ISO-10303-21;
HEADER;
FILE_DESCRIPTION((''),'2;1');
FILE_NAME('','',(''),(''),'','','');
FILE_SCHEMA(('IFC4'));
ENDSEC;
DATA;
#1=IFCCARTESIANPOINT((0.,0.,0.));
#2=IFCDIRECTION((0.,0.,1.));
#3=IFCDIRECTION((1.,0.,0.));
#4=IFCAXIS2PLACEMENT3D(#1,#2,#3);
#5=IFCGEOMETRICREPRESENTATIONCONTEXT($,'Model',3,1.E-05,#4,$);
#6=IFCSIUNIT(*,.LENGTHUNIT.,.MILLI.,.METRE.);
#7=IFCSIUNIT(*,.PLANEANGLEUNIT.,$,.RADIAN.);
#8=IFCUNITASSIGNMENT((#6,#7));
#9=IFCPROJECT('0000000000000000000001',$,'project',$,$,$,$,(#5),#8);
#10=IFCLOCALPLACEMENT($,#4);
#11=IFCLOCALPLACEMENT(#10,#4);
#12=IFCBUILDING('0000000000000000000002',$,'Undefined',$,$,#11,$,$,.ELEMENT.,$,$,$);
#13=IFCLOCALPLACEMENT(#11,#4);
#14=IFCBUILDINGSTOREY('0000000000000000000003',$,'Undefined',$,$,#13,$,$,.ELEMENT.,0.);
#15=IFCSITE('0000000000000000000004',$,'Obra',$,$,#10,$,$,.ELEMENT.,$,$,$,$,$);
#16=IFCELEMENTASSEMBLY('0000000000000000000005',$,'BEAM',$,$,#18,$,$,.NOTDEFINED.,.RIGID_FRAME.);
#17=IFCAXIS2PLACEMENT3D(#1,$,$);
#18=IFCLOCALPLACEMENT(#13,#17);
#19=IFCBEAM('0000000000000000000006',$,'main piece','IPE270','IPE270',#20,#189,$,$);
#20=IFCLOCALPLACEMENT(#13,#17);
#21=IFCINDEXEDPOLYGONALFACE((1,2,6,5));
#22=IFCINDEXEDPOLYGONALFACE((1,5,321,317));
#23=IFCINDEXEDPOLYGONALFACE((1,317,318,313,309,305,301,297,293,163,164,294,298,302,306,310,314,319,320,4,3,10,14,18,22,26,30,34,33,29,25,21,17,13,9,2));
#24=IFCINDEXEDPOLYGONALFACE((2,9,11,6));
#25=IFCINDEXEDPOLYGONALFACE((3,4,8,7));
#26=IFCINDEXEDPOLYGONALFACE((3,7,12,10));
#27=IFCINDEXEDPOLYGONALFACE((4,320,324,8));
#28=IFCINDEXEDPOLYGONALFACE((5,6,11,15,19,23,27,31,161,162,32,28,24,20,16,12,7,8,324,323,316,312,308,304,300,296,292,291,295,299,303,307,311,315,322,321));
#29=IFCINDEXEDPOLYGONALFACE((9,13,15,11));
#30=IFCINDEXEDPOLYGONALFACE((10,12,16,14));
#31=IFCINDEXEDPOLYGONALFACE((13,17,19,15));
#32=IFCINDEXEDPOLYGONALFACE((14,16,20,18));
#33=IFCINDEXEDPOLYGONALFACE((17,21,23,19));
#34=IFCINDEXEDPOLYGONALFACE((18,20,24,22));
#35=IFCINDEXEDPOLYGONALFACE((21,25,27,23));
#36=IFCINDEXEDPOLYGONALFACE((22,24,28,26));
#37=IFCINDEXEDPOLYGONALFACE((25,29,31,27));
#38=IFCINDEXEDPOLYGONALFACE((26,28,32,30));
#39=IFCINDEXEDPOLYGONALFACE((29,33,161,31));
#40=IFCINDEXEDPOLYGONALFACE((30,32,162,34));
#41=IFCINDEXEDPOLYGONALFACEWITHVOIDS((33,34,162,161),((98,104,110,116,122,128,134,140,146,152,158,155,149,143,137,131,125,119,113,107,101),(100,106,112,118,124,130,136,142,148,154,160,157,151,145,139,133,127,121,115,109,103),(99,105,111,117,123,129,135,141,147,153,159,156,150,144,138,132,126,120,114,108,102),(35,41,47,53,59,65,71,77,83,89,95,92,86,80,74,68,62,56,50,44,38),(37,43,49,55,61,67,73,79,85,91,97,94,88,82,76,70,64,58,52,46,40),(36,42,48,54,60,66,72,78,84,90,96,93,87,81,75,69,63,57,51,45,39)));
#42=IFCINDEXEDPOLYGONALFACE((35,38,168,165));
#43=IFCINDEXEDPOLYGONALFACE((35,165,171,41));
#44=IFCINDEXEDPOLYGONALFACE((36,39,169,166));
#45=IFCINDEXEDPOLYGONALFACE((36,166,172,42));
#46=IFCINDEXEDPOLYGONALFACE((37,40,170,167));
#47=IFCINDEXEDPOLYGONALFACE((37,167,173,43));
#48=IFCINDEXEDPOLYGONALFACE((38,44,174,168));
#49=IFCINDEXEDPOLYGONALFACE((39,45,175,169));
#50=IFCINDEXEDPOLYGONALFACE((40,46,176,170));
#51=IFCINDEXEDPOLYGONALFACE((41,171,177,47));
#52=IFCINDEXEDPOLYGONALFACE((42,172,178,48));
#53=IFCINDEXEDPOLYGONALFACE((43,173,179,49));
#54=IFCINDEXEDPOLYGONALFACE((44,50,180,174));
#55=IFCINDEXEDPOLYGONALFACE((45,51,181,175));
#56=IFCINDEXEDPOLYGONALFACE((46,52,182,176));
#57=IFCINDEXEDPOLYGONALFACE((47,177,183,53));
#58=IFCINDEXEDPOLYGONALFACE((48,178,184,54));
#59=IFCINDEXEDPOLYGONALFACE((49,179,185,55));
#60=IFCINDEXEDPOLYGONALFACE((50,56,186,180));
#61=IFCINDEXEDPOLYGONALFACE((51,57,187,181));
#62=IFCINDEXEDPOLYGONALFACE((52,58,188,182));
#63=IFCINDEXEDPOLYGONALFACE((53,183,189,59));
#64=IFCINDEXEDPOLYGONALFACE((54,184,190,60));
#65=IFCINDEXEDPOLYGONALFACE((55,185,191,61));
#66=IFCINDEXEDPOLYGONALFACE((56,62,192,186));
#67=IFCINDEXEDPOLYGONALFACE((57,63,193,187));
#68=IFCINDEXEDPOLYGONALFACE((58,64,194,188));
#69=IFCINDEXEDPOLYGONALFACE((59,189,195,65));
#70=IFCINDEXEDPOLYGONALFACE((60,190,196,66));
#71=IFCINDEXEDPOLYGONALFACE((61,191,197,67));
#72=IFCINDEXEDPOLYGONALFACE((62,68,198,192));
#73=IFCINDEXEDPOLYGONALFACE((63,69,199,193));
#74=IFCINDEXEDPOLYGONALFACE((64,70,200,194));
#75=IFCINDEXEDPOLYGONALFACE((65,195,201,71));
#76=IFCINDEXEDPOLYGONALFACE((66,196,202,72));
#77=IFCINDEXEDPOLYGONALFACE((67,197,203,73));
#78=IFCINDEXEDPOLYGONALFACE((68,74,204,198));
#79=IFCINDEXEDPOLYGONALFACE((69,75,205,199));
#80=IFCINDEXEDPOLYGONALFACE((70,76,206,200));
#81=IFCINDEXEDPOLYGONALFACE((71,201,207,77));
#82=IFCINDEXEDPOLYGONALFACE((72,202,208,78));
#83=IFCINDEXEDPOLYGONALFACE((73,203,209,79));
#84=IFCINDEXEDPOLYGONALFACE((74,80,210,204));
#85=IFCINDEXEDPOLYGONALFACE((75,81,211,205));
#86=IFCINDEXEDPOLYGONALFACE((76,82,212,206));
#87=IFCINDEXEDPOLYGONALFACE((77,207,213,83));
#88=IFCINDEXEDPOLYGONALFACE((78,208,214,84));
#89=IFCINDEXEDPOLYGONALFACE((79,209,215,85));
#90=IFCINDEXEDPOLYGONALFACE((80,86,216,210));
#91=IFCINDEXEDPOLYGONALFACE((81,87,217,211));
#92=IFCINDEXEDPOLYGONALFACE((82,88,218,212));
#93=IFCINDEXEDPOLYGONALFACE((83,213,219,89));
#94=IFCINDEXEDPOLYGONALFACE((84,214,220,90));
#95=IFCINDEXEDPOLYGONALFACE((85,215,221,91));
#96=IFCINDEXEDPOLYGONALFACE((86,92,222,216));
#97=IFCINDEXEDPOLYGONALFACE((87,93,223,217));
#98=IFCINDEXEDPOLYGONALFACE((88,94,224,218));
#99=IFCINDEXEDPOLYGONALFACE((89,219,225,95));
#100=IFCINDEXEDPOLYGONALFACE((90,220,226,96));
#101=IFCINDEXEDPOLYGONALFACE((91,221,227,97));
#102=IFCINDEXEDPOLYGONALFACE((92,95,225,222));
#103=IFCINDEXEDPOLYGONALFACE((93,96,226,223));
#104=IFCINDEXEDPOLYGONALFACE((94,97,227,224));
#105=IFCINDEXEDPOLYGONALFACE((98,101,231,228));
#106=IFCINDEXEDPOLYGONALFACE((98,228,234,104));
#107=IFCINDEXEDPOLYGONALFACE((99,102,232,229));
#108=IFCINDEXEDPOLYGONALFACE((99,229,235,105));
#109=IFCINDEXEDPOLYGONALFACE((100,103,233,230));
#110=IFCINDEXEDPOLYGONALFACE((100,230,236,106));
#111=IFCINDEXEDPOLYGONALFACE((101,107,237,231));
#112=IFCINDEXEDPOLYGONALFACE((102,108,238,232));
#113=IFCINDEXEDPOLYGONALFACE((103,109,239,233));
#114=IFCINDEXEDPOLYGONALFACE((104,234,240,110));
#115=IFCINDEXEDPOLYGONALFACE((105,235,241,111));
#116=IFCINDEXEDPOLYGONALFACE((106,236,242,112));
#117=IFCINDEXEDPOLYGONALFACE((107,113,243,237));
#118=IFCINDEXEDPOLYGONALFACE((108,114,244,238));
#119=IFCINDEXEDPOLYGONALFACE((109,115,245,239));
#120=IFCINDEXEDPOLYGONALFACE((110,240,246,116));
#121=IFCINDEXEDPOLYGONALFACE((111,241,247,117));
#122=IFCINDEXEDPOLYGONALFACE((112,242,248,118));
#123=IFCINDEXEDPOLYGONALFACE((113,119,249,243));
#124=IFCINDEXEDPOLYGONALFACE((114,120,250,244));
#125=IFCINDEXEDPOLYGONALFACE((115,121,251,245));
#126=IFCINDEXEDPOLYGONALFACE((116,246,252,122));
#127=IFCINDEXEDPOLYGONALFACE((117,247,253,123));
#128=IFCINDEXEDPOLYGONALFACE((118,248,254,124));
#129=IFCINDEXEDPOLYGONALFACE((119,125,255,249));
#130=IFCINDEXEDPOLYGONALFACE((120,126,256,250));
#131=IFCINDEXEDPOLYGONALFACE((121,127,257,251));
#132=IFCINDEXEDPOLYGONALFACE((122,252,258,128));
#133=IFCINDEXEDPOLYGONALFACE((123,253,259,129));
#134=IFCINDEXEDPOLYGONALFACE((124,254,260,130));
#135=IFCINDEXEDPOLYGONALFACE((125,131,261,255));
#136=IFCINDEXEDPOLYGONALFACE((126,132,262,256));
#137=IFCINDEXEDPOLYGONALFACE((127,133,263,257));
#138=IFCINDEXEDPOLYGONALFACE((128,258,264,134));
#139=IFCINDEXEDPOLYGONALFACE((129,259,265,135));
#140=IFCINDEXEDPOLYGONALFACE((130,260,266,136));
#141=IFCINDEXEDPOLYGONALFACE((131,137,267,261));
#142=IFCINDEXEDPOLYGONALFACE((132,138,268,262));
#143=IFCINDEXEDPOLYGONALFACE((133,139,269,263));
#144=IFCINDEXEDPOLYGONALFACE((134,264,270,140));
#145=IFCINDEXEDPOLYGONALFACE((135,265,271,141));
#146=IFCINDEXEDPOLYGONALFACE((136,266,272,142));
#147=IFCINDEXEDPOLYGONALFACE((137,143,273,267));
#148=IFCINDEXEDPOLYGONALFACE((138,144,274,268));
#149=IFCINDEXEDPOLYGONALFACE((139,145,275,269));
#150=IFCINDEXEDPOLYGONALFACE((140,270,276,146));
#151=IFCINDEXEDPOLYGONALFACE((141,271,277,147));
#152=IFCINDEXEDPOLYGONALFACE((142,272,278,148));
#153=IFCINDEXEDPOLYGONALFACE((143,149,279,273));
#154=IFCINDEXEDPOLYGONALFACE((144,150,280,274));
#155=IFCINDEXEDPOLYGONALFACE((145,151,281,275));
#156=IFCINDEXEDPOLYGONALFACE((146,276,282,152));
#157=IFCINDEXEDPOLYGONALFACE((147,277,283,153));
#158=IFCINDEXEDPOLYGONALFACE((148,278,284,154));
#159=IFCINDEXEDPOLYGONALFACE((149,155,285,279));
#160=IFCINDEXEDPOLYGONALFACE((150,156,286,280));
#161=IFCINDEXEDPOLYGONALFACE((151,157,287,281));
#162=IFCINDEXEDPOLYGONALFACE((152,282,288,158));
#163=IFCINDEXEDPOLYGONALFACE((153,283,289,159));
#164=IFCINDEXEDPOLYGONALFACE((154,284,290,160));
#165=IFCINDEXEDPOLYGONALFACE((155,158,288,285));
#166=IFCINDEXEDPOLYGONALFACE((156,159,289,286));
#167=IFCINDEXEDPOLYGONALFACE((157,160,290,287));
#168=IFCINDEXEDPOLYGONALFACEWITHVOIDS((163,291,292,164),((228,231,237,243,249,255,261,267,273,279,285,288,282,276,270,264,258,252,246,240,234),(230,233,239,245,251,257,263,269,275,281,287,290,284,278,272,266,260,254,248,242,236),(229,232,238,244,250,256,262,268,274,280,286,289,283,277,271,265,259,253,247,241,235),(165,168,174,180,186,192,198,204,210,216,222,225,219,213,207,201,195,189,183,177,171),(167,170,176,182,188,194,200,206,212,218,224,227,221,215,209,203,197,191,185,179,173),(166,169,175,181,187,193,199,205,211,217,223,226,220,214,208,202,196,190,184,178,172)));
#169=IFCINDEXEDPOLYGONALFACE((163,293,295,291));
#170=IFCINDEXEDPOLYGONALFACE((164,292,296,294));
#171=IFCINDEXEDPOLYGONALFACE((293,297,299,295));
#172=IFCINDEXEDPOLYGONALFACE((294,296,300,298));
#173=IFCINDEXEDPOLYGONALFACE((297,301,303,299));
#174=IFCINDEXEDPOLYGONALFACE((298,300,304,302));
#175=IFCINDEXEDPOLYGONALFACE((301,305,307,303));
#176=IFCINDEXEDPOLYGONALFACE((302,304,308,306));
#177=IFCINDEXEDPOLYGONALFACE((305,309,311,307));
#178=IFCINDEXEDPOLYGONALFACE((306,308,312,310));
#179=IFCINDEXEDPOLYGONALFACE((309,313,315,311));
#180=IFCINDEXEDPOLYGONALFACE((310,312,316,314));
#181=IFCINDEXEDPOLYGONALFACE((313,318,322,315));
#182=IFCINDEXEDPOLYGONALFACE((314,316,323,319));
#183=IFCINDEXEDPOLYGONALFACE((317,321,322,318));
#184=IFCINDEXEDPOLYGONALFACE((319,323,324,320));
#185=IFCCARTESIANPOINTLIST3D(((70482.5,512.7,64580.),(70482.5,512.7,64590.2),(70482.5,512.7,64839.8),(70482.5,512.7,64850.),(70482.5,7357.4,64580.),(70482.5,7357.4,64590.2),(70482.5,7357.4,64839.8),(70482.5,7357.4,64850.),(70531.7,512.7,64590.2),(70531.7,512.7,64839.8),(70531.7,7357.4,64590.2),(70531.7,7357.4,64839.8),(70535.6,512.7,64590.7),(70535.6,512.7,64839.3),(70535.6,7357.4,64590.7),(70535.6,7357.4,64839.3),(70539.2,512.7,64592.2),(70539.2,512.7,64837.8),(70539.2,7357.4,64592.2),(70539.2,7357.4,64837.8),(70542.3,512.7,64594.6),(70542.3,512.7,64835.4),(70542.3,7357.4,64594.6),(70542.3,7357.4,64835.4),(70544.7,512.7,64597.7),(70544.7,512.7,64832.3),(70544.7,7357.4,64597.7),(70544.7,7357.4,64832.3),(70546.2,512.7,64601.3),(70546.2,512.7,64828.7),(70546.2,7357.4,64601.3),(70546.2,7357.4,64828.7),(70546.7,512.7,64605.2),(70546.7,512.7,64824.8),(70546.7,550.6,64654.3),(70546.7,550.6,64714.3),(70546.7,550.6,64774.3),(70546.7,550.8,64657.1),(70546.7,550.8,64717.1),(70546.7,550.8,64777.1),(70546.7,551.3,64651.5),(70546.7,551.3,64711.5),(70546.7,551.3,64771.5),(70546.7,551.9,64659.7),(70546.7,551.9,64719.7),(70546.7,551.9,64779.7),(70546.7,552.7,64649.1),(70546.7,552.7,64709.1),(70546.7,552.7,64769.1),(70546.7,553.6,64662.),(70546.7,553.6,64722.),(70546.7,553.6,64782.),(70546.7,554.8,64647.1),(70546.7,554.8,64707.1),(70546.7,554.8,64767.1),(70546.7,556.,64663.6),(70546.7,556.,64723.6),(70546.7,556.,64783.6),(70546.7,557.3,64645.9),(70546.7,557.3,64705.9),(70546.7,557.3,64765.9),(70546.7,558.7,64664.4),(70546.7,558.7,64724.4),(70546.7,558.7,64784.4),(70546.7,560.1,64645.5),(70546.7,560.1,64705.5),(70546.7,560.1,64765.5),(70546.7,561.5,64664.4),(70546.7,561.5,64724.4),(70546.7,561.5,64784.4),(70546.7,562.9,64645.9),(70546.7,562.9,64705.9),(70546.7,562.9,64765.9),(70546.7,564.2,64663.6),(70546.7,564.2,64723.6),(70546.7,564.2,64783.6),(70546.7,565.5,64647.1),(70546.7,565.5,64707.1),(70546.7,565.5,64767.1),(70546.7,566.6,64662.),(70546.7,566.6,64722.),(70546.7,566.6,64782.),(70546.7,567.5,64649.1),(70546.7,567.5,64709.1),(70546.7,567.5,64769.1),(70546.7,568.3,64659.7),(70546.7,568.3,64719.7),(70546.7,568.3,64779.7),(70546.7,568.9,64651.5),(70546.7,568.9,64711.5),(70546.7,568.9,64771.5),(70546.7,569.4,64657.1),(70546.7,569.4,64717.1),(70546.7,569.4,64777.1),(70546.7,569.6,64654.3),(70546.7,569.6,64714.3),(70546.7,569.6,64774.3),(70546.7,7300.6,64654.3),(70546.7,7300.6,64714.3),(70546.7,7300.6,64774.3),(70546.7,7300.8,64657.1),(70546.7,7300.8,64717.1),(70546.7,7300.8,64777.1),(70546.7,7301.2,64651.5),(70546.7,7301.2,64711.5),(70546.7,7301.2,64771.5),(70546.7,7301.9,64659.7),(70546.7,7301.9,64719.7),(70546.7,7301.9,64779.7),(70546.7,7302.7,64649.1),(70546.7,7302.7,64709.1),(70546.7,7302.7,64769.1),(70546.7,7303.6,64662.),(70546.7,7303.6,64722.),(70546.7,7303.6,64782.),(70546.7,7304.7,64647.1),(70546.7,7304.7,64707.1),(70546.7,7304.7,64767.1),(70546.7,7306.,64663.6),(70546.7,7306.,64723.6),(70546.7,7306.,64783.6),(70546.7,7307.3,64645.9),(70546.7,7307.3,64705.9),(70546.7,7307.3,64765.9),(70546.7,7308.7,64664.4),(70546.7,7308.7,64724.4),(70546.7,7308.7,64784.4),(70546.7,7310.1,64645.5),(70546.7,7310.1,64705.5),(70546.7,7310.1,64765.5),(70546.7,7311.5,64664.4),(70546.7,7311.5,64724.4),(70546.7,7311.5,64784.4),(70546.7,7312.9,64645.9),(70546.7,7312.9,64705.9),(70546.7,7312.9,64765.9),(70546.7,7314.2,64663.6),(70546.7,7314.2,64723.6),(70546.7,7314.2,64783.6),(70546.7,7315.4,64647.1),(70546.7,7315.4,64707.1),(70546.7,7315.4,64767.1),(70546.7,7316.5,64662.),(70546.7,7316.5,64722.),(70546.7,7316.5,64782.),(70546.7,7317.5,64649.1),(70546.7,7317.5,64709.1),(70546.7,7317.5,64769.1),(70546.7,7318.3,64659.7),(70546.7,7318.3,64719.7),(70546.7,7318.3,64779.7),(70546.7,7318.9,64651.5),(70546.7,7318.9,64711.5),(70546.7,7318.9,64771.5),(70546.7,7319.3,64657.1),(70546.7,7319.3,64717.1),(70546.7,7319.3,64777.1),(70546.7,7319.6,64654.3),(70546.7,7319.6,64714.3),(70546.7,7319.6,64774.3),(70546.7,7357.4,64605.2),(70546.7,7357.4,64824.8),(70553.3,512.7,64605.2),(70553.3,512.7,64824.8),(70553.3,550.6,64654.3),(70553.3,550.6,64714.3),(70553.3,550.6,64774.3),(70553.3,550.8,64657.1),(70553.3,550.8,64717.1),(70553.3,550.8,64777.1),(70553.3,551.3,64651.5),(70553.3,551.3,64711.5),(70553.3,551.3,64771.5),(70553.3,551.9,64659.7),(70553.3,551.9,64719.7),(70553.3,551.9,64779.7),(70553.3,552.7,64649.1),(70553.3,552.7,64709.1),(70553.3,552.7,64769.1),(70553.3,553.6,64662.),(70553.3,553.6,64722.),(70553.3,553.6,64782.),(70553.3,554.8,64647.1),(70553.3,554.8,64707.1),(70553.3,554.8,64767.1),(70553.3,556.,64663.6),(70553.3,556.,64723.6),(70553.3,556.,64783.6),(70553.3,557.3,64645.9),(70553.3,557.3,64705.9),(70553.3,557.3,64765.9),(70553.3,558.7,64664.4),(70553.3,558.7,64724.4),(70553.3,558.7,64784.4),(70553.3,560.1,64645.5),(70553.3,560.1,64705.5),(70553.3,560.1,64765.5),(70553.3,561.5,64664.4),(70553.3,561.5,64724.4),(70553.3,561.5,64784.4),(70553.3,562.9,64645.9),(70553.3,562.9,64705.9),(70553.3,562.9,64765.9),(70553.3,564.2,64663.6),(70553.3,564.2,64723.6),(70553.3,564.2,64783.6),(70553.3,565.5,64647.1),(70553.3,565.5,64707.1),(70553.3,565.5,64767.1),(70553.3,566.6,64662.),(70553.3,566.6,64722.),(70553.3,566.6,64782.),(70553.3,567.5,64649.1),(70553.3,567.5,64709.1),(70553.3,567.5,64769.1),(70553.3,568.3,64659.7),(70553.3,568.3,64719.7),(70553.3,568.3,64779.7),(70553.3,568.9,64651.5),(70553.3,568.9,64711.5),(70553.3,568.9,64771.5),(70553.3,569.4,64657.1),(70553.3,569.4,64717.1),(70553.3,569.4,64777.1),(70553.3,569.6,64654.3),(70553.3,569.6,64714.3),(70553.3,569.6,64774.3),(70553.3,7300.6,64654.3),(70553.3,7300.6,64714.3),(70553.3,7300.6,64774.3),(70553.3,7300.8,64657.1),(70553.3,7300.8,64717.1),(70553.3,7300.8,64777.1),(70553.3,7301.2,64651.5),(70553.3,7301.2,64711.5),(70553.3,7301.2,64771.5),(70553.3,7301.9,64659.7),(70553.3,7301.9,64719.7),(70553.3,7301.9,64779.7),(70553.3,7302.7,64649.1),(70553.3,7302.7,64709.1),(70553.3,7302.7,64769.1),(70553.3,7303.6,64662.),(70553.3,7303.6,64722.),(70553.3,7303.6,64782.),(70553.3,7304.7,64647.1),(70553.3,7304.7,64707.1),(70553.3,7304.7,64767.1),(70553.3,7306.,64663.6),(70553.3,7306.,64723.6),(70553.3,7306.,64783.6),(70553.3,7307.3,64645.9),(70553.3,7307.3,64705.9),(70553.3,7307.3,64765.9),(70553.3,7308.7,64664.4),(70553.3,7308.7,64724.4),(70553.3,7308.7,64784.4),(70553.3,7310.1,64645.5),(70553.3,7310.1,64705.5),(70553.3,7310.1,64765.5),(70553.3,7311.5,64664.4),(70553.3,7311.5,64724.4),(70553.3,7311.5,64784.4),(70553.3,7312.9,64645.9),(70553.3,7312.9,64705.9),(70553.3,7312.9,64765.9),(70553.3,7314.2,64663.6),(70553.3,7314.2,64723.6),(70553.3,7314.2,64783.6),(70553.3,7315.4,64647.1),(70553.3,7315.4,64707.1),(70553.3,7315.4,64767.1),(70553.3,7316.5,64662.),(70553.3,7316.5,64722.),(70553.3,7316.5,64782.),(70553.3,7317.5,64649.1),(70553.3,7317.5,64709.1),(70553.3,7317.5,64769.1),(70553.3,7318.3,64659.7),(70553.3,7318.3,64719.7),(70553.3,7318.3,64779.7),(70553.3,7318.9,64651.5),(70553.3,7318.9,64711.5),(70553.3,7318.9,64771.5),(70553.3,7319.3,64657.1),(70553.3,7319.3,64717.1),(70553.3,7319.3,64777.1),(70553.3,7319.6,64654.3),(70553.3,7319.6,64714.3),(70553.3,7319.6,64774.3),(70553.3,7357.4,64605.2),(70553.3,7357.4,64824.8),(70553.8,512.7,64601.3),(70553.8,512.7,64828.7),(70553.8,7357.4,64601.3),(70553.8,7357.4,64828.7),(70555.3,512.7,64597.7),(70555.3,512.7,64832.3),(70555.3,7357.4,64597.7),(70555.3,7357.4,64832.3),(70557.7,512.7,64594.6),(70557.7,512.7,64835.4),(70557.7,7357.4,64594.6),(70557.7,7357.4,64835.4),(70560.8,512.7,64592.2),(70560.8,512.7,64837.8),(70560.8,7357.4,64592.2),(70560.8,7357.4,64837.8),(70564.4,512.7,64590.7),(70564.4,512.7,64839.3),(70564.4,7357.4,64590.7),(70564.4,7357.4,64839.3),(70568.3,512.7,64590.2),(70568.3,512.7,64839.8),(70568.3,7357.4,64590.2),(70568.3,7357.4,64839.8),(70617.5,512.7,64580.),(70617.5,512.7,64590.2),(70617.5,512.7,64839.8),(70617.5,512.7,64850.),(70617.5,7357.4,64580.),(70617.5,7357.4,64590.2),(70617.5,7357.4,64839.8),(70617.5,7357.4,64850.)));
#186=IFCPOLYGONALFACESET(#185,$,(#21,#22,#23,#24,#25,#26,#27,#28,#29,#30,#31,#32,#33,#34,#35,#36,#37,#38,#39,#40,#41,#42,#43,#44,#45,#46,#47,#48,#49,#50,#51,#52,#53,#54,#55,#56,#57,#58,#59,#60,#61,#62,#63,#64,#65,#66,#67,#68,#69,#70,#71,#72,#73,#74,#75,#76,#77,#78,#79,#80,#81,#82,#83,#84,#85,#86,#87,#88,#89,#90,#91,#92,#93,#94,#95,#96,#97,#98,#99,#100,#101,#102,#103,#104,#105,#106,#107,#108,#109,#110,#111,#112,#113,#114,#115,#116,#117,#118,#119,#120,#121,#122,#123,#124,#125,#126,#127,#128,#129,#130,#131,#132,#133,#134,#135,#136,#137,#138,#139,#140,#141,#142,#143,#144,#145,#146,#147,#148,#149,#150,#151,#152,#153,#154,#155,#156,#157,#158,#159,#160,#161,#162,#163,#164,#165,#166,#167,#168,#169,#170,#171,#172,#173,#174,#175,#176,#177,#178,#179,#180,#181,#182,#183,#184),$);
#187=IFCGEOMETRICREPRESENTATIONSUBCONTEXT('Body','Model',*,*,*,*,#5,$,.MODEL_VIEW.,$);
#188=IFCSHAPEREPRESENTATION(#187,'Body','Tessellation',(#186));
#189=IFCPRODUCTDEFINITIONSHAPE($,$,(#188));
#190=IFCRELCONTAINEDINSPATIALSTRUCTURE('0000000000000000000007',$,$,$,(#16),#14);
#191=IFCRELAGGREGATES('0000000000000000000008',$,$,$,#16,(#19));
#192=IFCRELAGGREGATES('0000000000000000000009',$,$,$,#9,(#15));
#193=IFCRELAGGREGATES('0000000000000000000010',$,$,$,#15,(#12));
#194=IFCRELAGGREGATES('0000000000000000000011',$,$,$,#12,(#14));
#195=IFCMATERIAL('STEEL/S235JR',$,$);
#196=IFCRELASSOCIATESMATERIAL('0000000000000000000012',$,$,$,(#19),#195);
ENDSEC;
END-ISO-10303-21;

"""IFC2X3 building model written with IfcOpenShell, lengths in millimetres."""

from ifc_helpers import new_model, si_unit, frame, origin_with_axes, origin_2d_with_axis, place, context, subcontext, project, spatial, circle, i_section, extrude, clip, halfspace, source, transform, mapped, material, element, aggregate, save


model = new_model("IFC2X3")

# Units and contexts
model_context = context("Model", 3, precision=1e-05, world=origin_with_axes())
body_context = subcontext(model_context, "Body", "Model", "MODEL_VIEW")
ifc_project = project(units=[si_unit("LENGTHUNIT", "METRE", prefix="MILLI"), si_unit("PLANEANGLEUNIT", "RADIAN")], contexts=[model_context])

# Site, building, storey
site_placement = place(None, origin_with_axes())
site = spatial("IfcSite", under=ifc_project, at=site_placement, Name="Obra", CompositionType="ELEMENT")
building_placement = place(site_placement, origin_with_axes())
building = spatial("IfcBuilding", under=site, at=building_placement, Name="Undefined", CompositionType="ELEMENT")
storey_placement = place(building_placement, origin_with_axes())
storey = spatial("IfcBuildingStorey", under=building, at=storey_placement, Name="Undefined", CompositionType="ELEMENT", Elevation=0.0)

# Element assembly, beam, openings
ifc_material_1 = material(Name="STEEL/S235JR")
shared_shape_1 = source(origin_with_axes(), body_context, "Body", "SweptSolid", [
    extrude(circle(Radius=9.5, at=origin_2d_with_axis()), frame((0.0, -3.4, 0.0), z_axis=(0.0, 1.0, 0.0), x_axis=(1.0, 0.0, 0.0)), (0.0, 0.0, 1.0), 6.8),
])
shared_shape_2 = source(origin_with_axes(), body_context, "Body", "SweptSolid", [
    extrude(circle(Radius=9.5, at=origin_2d_with_axis()), frame((0.0, -3.4, 0.0), z_axis=(0.0, 1.0, 0.0), x_axis=(1.0, 0.0, 0.0)), (0.0, 0.0, 1.0), 6.8),
])
assembly_1_placement = place(storey_placement, origin_with_axes())
assembly_1 = element("IfcElementAssembly", 1, at=assembly_1_placement, inside=storey, Name="BEAM", AssemblyPlace="NOTDEFINED", PredefinedType="RIGID_FRAME")
beam_1_placement = place(assembly_1_placement, frame((70550.0, 512.7, 64715.0), z_axis=(0.0, 0.0, 1.0), x_axis=(0.0, 1.0, 0.0)))
beam_1 = element("IfcBeam", 2, at=beam_1_placement, material=ifc_material_1, Name="main piece", Description="IPE270", ObjectType="IPE270", context=body_context, shape_type="Clipping", body=[
    clip(clip(extrude(i_section(OverallWidth=135.0, OverallDepth=270.0, WebThickness=6.6, FlangeThickness=10.2, FilletRadius=15.0, at=origin_2d_with_axis()), frame((6844.7, 0.0, 0.0), z_axis=(-1.0, 0.0, 0.0), x_axis=(0.0, -1.0, 0.0)), (0.0, 0.0, 1.0), 6844.7), halfspace(frame((6846.9, -60.0, -120.0), z_axis=(1.0, 0.0, 0.0), x_axis=(0.0, 0.0, 1.0)), False)), halfspace(frame((-2.2, 60.0, -120.0), z_axis=(-1.0, -0.000021, 0.0), x_axis=(0.0, 0.0, 1.0)), False)),
])
opening_1_placement = place(assembly_1_placement, frame((70550.0, 7360.1, 64835.0), z_axis=(-0.000019, -1.0, 0.0), x_axis=(0.0, 0.0, -1.0)))
element("IfcOpeningElement", 3, at=opening_1_placement, cuts=beam_1, ObjectType="Opening", context=body_context, shape_type="MappedRepresentation", body=[
    mapped(shared_shape_1, transform((60.0, 0.0, 50.0))),
    mapped(shared_shape_1, transform((120.0, 0.0, 50.0))),
    mapped(shared_shape_1, transform((180.0, 0.0, 50.0))),
])
opening_2_placement = place(assembly_1_placement, frame((70550.0, 510.1, 64835.0), z_axis=(-0.000002, 1.0, 0.0), x_axis=(0.0, 0.0, -1.0)))
element("IfcOpeningElement", 4, at=opening_2_placement, cuts=beam_1, ObjectType="Opening", context=body_context, shape_type="MappedRepresentation", body=[
    mapped(shared_shape_2, transform((60.0, 0.0, 50.0))),
    mapped(shared_shape_2, transform((120.0, 0.0, 50.0))),
    mapped(shared_shape_2, transform((180.0, 0.0, 50.0))),
])
aggregate(assembly_1, [beam_1])

save(model, "model.ifc")
